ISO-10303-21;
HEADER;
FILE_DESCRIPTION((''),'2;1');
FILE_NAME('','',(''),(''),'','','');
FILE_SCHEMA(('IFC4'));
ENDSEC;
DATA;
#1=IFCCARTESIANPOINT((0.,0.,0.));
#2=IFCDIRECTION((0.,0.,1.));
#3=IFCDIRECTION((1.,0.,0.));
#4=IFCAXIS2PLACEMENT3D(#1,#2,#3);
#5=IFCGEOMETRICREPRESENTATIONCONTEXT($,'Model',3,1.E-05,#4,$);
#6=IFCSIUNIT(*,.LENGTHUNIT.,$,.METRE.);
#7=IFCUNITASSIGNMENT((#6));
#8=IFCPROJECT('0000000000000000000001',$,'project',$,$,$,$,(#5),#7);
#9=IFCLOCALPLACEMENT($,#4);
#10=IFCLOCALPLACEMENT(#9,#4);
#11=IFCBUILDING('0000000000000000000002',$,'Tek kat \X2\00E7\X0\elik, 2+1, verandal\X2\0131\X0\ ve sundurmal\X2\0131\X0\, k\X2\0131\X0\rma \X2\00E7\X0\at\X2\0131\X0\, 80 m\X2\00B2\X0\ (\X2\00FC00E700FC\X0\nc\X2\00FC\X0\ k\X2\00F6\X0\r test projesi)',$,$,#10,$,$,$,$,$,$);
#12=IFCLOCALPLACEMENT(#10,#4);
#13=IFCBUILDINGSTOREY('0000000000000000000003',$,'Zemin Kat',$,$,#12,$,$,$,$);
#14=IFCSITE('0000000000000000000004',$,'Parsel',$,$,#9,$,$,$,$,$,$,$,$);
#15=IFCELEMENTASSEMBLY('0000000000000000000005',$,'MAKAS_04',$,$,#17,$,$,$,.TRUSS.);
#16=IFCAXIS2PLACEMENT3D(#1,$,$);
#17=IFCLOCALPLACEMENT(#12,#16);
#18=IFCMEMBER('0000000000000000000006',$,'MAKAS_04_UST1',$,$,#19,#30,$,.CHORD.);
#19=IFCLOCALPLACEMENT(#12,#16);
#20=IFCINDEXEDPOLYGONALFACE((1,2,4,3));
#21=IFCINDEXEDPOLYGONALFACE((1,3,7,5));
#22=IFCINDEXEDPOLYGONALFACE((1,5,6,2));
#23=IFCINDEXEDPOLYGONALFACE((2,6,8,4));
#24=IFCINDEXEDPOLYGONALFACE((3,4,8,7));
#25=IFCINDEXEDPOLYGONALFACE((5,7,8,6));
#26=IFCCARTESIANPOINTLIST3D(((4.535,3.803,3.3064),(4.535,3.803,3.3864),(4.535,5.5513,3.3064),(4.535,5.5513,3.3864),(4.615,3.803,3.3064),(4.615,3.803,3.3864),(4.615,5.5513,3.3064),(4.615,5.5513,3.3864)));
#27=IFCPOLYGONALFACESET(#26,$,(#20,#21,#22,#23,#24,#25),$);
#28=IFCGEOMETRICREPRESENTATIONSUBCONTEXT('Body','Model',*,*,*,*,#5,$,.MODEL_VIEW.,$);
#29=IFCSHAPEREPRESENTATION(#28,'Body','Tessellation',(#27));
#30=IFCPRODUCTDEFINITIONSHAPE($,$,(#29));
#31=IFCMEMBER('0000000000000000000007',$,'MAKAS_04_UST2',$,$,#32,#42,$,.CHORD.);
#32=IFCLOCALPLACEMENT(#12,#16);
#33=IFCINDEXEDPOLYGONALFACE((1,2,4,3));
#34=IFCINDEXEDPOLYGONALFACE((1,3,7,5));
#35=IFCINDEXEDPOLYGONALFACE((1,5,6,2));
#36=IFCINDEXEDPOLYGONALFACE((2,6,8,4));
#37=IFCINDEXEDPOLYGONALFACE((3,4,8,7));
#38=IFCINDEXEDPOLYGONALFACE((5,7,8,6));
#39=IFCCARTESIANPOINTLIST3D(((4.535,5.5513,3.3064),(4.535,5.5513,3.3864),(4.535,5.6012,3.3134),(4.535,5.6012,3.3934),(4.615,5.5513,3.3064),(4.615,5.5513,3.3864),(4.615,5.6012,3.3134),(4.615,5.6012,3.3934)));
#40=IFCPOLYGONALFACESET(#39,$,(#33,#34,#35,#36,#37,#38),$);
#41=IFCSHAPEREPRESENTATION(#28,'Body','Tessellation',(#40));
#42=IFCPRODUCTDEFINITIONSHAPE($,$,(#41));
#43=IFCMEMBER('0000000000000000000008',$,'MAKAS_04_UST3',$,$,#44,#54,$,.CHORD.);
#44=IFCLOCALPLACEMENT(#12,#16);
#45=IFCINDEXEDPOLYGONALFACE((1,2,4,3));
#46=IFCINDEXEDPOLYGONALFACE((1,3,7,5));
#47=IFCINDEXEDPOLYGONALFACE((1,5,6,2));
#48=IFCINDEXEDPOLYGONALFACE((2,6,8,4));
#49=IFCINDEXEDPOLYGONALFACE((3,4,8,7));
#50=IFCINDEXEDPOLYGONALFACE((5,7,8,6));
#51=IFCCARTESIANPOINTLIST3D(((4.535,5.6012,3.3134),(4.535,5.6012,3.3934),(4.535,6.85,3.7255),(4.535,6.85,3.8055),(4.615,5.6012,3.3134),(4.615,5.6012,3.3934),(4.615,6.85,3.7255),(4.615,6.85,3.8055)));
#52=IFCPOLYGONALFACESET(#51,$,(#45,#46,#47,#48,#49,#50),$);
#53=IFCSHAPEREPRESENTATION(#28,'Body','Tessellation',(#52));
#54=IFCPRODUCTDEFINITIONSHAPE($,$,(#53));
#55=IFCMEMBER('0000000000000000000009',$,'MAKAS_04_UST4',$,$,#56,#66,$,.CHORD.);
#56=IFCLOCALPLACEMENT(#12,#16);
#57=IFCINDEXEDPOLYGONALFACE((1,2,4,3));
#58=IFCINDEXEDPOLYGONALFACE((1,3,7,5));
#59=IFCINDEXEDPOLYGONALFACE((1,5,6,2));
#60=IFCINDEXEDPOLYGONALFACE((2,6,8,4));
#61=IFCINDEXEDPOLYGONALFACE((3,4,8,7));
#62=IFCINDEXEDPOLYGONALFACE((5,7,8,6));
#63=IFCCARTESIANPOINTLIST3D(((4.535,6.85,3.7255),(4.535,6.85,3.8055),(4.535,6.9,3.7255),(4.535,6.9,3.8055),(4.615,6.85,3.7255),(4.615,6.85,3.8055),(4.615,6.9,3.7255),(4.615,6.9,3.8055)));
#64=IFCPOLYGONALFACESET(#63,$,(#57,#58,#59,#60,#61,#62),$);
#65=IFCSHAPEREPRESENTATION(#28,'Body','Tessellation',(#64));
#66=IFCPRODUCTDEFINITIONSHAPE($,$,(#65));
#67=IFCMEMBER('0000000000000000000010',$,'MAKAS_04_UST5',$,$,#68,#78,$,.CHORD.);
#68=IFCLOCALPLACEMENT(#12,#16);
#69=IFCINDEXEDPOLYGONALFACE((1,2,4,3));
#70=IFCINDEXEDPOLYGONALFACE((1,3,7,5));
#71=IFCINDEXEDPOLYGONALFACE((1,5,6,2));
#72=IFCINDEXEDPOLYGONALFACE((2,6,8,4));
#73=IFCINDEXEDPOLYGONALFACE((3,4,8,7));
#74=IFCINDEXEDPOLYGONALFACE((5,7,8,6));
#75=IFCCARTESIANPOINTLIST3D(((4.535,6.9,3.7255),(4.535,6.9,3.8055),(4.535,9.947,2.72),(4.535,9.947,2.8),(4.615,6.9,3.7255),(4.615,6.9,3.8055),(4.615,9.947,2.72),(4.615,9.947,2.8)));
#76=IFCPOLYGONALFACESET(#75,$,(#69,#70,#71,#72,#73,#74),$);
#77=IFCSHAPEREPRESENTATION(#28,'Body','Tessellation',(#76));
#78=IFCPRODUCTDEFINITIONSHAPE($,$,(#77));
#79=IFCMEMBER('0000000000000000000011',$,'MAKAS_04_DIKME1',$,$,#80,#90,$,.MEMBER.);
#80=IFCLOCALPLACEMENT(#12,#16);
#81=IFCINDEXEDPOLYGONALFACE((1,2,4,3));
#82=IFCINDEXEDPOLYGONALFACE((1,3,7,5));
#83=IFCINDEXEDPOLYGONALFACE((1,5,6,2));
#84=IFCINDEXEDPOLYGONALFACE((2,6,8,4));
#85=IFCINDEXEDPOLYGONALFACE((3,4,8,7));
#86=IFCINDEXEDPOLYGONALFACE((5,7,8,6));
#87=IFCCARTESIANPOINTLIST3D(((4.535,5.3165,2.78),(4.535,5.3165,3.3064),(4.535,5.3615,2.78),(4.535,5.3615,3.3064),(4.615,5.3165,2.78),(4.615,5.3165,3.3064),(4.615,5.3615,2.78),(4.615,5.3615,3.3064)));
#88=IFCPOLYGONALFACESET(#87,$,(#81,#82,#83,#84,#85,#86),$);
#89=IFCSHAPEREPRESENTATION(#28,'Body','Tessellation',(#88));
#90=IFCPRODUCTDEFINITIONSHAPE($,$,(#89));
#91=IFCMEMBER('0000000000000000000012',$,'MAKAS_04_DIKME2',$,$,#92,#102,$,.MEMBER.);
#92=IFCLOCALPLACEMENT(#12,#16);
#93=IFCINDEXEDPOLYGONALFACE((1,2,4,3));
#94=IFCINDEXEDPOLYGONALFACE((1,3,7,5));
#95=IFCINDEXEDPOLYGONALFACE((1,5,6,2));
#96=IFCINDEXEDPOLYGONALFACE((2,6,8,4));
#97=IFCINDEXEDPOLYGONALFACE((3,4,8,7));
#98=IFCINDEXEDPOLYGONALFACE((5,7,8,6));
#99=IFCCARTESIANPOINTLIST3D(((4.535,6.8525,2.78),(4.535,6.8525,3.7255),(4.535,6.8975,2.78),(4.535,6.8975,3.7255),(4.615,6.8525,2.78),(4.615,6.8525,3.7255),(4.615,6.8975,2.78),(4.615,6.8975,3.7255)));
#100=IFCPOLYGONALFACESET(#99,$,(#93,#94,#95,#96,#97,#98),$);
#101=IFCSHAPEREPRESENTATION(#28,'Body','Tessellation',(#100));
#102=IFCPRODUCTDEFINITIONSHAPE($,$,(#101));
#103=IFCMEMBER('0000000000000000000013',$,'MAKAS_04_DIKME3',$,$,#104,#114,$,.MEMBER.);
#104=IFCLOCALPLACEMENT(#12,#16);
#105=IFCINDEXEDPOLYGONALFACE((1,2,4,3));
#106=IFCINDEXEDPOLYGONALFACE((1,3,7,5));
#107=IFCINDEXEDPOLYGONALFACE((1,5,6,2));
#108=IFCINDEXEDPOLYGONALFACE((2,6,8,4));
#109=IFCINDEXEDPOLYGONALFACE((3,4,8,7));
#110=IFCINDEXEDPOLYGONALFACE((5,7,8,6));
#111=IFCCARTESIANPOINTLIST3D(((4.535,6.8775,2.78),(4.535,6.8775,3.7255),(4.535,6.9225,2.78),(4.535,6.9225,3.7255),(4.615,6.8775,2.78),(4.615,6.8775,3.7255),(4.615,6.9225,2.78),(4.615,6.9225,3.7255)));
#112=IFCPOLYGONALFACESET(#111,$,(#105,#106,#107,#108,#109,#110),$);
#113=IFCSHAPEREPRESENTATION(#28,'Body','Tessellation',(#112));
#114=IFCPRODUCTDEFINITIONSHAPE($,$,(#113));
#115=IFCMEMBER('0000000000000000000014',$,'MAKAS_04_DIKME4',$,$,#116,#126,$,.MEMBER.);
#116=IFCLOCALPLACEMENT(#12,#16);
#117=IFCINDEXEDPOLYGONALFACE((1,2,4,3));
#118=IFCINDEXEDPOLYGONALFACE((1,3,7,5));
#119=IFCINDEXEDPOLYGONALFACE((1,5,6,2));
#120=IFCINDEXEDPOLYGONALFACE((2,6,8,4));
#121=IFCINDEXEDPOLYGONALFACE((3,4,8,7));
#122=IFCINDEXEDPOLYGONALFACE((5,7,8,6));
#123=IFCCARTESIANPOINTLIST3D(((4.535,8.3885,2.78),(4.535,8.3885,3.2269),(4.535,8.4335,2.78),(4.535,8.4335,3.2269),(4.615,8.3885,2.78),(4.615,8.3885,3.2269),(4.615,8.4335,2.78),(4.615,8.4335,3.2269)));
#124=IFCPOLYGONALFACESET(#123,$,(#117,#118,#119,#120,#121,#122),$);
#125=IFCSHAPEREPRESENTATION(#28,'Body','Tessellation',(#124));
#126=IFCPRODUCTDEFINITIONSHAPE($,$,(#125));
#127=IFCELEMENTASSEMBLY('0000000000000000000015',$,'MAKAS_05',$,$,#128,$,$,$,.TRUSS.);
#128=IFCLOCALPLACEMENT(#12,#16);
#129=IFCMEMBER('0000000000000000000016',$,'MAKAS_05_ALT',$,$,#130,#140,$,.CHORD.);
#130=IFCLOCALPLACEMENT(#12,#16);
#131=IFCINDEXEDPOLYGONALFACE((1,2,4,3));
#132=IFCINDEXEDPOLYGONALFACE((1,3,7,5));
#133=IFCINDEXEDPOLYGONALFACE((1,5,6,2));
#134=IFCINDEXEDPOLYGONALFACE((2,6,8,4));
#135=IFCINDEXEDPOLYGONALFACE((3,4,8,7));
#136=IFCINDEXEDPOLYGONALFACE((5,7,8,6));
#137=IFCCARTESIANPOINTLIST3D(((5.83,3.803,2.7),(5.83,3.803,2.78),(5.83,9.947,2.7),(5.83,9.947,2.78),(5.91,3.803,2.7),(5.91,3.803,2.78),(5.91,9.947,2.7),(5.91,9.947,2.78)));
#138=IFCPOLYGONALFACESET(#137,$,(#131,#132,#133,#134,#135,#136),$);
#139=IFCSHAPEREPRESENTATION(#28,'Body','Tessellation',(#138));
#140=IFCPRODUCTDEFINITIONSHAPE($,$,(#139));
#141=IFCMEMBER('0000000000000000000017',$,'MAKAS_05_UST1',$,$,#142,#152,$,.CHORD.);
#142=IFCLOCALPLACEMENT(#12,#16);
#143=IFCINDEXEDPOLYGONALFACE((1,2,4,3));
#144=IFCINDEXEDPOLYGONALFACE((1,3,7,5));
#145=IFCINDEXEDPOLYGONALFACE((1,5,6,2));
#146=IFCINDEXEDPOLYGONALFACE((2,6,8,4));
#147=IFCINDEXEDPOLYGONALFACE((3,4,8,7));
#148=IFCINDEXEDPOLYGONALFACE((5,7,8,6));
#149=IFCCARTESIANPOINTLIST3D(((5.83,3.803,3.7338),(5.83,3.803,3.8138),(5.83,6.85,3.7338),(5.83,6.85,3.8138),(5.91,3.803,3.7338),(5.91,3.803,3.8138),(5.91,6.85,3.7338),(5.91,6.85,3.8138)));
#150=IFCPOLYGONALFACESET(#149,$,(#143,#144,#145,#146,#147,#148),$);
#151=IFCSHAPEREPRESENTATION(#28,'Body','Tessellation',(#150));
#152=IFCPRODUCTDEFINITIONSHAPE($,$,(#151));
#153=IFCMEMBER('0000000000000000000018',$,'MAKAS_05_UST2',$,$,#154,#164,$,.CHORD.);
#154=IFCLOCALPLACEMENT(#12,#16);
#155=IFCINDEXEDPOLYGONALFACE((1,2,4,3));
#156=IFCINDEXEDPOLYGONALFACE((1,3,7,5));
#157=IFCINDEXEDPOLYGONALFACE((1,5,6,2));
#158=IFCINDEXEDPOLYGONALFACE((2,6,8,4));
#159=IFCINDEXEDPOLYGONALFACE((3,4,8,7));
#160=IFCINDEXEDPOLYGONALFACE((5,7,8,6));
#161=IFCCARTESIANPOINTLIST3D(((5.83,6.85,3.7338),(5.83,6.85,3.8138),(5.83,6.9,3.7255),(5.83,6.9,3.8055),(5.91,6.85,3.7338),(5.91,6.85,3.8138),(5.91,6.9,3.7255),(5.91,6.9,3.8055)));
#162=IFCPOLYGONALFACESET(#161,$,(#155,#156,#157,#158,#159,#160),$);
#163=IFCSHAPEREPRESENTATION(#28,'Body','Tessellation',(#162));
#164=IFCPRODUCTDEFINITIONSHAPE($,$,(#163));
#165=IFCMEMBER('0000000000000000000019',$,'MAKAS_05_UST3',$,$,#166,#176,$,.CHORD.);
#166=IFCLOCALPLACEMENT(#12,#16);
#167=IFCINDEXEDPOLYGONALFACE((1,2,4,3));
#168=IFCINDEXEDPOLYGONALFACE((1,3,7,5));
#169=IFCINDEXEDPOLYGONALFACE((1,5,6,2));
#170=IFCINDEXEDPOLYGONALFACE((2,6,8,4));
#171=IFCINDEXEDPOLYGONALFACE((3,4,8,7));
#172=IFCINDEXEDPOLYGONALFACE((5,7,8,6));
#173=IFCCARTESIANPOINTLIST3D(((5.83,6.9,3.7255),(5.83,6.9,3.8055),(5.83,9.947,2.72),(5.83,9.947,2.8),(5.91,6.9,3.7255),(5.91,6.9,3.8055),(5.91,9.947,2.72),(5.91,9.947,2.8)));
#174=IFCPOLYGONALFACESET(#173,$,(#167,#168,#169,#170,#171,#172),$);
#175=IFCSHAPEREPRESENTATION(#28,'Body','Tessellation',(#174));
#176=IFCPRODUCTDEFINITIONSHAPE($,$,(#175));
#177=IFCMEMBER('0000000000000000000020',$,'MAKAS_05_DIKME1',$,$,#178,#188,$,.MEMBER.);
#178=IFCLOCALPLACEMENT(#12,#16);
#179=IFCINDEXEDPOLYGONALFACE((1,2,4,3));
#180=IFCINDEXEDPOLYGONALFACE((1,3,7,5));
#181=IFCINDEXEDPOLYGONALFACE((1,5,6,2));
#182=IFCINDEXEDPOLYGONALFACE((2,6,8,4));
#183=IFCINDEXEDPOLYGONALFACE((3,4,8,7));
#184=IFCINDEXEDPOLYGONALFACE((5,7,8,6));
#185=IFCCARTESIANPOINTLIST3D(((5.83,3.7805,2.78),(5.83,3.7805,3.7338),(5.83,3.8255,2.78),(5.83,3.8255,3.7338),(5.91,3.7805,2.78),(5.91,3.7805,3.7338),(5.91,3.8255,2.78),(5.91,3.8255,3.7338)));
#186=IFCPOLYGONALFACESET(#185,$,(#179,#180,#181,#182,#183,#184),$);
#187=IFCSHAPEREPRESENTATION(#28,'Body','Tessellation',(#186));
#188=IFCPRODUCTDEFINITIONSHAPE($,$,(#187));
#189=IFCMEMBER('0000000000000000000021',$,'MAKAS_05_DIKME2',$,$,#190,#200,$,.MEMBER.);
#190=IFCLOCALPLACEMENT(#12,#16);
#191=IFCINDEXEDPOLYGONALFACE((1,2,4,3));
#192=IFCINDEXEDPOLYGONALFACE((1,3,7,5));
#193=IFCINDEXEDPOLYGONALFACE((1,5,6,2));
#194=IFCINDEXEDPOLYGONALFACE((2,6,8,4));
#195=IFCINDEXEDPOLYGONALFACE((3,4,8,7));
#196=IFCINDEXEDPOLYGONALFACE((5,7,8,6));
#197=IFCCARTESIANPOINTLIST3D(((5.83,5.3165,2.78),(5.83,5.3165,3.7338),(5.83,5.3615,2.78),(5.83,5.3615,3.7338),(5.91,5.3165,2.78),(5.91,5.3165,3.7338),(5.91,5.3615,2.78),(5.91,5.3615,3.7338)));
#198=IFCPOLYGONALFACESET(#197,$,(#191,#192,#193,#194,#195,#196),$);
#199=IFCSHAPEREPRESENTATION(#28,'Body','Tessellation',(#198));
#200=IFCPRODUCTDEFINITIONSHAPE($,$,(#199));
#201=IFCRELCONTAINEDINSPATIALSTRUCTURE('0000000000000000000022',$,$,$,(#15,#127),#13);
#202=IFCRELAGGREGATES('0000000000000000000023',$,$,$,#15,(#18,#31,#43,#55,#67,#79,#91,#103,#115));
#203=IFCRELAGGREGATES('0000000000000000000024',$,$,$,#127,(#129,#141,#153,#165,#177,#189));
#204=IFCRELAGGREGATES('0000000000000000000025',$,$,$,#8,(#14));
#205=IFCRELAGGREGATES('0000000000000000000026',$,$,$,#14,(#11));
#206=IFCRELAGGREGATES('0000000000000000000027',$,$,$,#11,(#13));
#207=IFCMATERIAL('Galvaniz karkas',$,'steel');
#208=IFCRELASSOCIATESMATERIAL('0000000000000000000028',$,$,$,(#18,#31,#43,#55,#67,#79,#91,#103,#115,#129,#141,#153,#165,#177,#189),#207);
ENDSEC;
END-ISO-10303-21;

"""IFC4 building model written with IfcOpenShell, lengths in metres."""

from ifc_helpers import new_model, si_unit, frame, origin_with_axes, place, context, subcontext, project, spatial, line, indexed_curve, outline, extrude, material, element, aggregate, save


model = new_model("IFC4")

# Units and contexts
model_context = context("Model", 3, precision=1e-05, world=origin_with_axes())
body_context = subcontext(model_context, "Body", "Model", "MODEL_VIEW")
ifc_project = project(units=[si_unit("LENGTHUNIT", "METRE")], contexts=[model_context])

# Site, building, storey
site_placement = place(None, origin_with_axes())
site = spatial("IfcSite", under=ifc_project, at=site_placement, Name="Parsel")
building_placement = place(site_placement, origin_with_axes())
building = spatial("IfcBuilding", under=site, at=building_placement, Name="Tek kat çelik, 2+1, verandalı ve sundurmalı, kırma çatı, 80 m² (üçüncü kör test projesi)")
storey_placement = place(building_placement, origin_with_axes())
storey = spatial("IfcBuildingStorey", under=building, at=storey_placement, Name="Zemin Kat")

# Element assemblies, members
assembly_1_placement = place(storey_placement, origin_with_axes())
assembly_1 = element("IfcElementAssembly", 1, at=assembly_1_placement, inside=storey, Name="MAKAS_04", PredefinedType="TRUSS")
ifc_material = material(Name="Galvaniz karkas", Category="steel")
member_1_placement = place(assembly_1_placement, origin_with_axes())
member_1 = element("IfcMember", 2, at=member_1_placement, material=ifc_material, Name="MAKAS_04_UST1", PredefinedType="CHORD", context=body_context, shape_type="SweptSolid", body=[
    extrude(outline(indexed_curve([(3.803, 3.3064), (5.5513, 3.3064), (5.5513, 3.3864), (3.803, 3.3864)], segments=[line(1, 2, 3, 4, 1)])), frame((4.535, 0.0, 0.0), z_axis=(1.0, 0.0, 0.0), x_axis=(0.0, 1.0, 0.0)), (0.0, 0.0, 1.0), 0.08),
])
member_2_placement = place(assembly_1_placement, origin_with_axes())
member_2 = element("IfcMember", 3, at=member_2_placement, material=ifc_material, Name="MAKAS_04_UST2", PredefinedType="CHORD", context=body_context, shape_type="SweptSolid", body=[
    extrude(outline(indexed_curve([(5.5513, 3.3064), (5.6012, 3.3134), (5.6012, 3.3934), (5.5513, 3.3864)], segments=[line(1, 2, 3, 4, 1)])), frame((4.535, 0.0, 0.0), z_axis=(1.0, 0.0, 0.0), x_axis=(0.0, 1.0, 0.0)), (0.0, 0.0, 1.0), 0.08),
])
member_3_placement = place(assembly_1_placement, origin_with_axes())
member_3 = element("IfcMember", 4, at=member_3_placement, material=ifc_material, Name="MAKAS_04_UST3", PredefinedType="CHORD", context=body_context, shape_type="SweptSolid", body=[
    extrude(outline(indexed_curve([(5.6012, 3.3134), (6.85, 3.7255), (6.85, 3.8055), (5.6012, 3.3934)], segments=[line(1, 2, 3, 4, 1)])), frame((4.535, 0.0, 0.0), z_axis=(1.0, 0.0, 0.0), x_axis=(0.0, 1.0, 0.0)), (0.0, 0.0, 1.0), 0.08),
])
member_4_placement = place(assembly_1_placement, origin_with_axes())
member_4 = element("IfcMember", 5, at=member_4_placement, material=ifc_material, Name="MAKAS_04_UST4", PredefinedType="CHORD", context=body_context, shape_type="SweptSolid", body=[
    extrude(outline(indexed_curve([(6.85, 3.7255), (6.9, 3.7255), (6.9, 3.8055), (6.85, 3.8055)], segments=[line(1, 2, 3, 4, 1)])), frame((4.535, 0.0, 0.0), z_axis=(1.0, 0.0, 0.0), x_axis=(0.0, 1.0, 0.0)), (0.0, 0.0, 1.0), 0.08),
])
member_5_placement = place(assembly_1_placement, origin_with_axes())
member_5 = element("IfcMember", 6, at=member_5_placement, material=ifc_material, Name="MAKAS_04_UST5", PredefinedType="CHORD", context=body_context, shape_type="SweptSolid", body=[
    extrude(outline(indexed_curve([(6.9, 3.7255), (9.947, 2.72), (9.947, 2.8), (6.9, 3.8055)], segments=[line(1, 2, 3, 4, 1)])), frame((4.535, 0.0, 0.0), z_axis=(1.0, 0.0, 0.0), x_axis=(0.0, 1.0, 0.0)), (0.0, 0.0, 1.0), 0.08),
])
member_6_placement = place(assembly_1_placement, origin_with_axes())
member_6 = element("IfcMember", 7, at=member_6_placement, material=ifc_material, Name="MAKAS_04_DIKME1", PredefinedType="MEMBER", context=body_context, shape_type="SweptSolid", body=[
    extrude(outline(indexed_curve([(5.3165, 2.78), (5.3615, 2.78), (5.3615, 3.3064), (5.3165, 3.3064)], segments=[line(1, 2, 3, 4, 1)])), frame((4.535, 0.0, 0.0), z_axis=(1.0, 0.0, 0.0), x_axis=(0.0, 1.0, 0.0)), (0.0, 0.0, 1.0), 0.08),
])
member_7_placement = place(assembly_1_placement, origin_with_axes())
member_7 = element("IfcMember", 8, at=member_7_placement, material=ifc_material, Name="MAKAS_04_DIKME2", PredefinedType="MEMBER", context=body_context, shape_type="SweptSolid", body=[
    extrude(outline(indexed_curve([(6.8525, 2.78), (6.8975, 2.78), (6.8975, 3.7255), (6.8525, 3.7255)], segments=[line(1, 2, 3, 4, 1)])), frame((4.535, 0.0, 0.0), z_axis=(1.0, 0.0, 0.0), x_axis=(0.0, 1.0, 0.0)), (0.0, 0.0, 1.0), 0.08),
])
member_8_placement = place(assembly_1_placement, origin_with_axes())
member_8 = element("IfcMember", 9, at=member_8_placement, material=ifc_material, Name="MAKAS_04_DIKME3", PredefinedType="MEMBER", context=body_context, shape_type="SweptSolid", body=[
    extrude(outline(indexed_curve([(6.8775, 2.78), (6.9225, 2.78), (6.9225, 3.7255), (6.8775, 3.7255)], segments=[line(1, 2, 3, 4, 1)])), frame((4.535, 0.0, 0.0), z_axis=(1.0, 0.0, 0.0), x_axis=(0.0, 1.0, 0.0)), (0.0, 0.0, 1.0), 0.08),
])
member_9_placement = place(assembly_1_placement, origin_with_axes())
member_9 = element("IfcMember", 10, at=member_9_placement, material=ifc_material, Name="MAKAS_04_DIKME4", PredefinedType="MEMBER", context=body_context, shape_type="SweptSolid", body=[
    extrude(outline(indexed_curve([(8.3885, 2.78), (8.4335, 2.78), (8.4335, 3.2269), (8.3885, 3.2269)], segments=[line(1, 2, 3, 4, 1)])), frame((4.535, 0.0, 0.0), z_axis=(1.0, 0.0, 0.0), x_axis=(0.0, 1.0, 0.0)), (0.0, 0.0, 1.0), 0.08),
])
aggregate(assembly_1, [member_1, member_2, member_3, member_4, member_5, member_6, member_7, member_8, member_9])
assembly_2_placement = place(storey_placement, origin_with_axes())
assembly_2 = element("IfcElementAssembly", 11, at=assembly_2_placement, inside=storey, Name="MAKAS_05", PredefinedType="TRUSS")
member_10_placement = place(assembly_2_placement, origin_with_axes())
member_10 = element("IfcMember", 12, at=member_10_placement, material=ifc_material, Name="MAKAS_05_ALT", PredefinedType="CHORD", context=body_context, shape_type="SweptSolid", body=[
    extrude(outline(indexed_curve([(3.803, 2.7), (9.947, 2.7), (9.947, 2.78), (3.803, 2.78)], segments=[line(1, 2, 3, 4, 1)])), frame((5.83, 0.0, 0.0), z_axis=(1.0, 0.0, 0.0), x_axis=(0.0, 1.0, 0.0)), (0.0, 0.0, 1.0), 0.08),
])
member_11_placement = place(assembly_2_placement, origin_with_axes())
member_11 = element("IfcMember", 13, at=member_11_placement, material=ifc_material, Name="MAKAS_05_UST1", PredefinedType="CHORD", context=body_context, shape_type="SweptSolid", body=[
    extrude(outline(indexed_curve([(3.803, 3.7338), (6.85, 3.7338), (6.85, 3.8138), (3.803, 3.8138)], segments=[line(1, 2, 3, 4, 1)])), frame((5.83, 0.0, 0.0), z_axis=(1.0, 0.0, 0.0), x_axis=(0.0, 1.0, 0.0)), (0.0, 0.0, 1.0), 0.08),
])
member_12_placement = place(assembly_2_placement, origin_with_axes())
member_12 = element("IfcMember", 14, at=member_12_placement, material=ifc_material, Name="MAKAS_05_UST2", PredefinedType="CHORD", context=body_context, shape_type="SweptSolid", body=[
    extrude(outline(indexed_curve([(6.85, 3.7338), (6.9, 3.7255), (6.9, 3.8055), (6.85, 3.8138)], segments=[line(1, 2, 3, 4, 1)])), frame((5.83, 0.0, 0.0), z_axis=(1.0, 0.0, 0.0), x_axis=(0.0, 1.0, 0.0)), (0.0, 0.0, 1.0), 0.08),
])
member_13_placement = place(assembly_2_placement, origin_with_axes())
member_13 = element("IfcMember", 15, at=member_13_placement, material=ifc_material, Name="MAKAS_05_UST3", PredefinedType="CHORD", context=body_context, shape_type="SweptSolid", body=[
    extrude(outline(indexed_curve([(6.9, 3.7255), (9.947, 2.72), (9.947, 2.8), (6.9, 3.8055)], segments=[line(1, 2, 3, 4, 1)])), frame((5.83, 0.0, 0.0), z_axis=(1.0, 0.0, 0.0), x_axis=(0.0, 1.0, 0.0)), (0.0, 0.0, 1.0), 0.08),
])
member_14_placement = place(assembly_2_placement, origin_with_axes())
member_14 = element("IfcMember", 16, at=member_14_placement, material=ifc_material, Name="MAKAS_05_DIKME1", PredefinedType="MEMBER", context=body_context, shape_type="SweptSolid", body=[
    extrude(outline(indexed_curve([(3.7805, 2.78), (3.8255, 2.78), (3.8255, 3.7338), (3.7805, 3.7338)], segments=[line(1, 2, 3, 4, 1)])), frame((5.83, 0.0, 0.0), z_axis=(1.0, 0.0, 0.0), x_axis=(0.0, 1.0, 0.0)), (0.0, 0.0, 1.0), 0.08),
])
member_15_placement = place(assembly_2_placement, origin_with_axes())
member_15 = element("IfcMember", 17, at=member_15_placement, material=ifc_material, Name="MAKAS_05_DIKME2", PredefinedType="MEMBER", context=body_context, shape_type="SweptSolid", body=[
    extrude(outline(indexed_curve([(5.3165, 2.78), (5.3615, 2.78), (5.3615, 3.7338), (5.3165, 3.7338)], segments=[line(1, 2, 3, 4, 1)])), frame((5.83, 0.0, 0.0), z_axis=(1.0, 0.0, 0.0), x_axis=(0.0, 1.0, 0.0)), (0.0, 0.0, 1.0), 0.08),
])
aggregate(assembly_2, [member_10, member_11, member_12, member_13, member_14, member_15])

save(model, "model.ifc")
